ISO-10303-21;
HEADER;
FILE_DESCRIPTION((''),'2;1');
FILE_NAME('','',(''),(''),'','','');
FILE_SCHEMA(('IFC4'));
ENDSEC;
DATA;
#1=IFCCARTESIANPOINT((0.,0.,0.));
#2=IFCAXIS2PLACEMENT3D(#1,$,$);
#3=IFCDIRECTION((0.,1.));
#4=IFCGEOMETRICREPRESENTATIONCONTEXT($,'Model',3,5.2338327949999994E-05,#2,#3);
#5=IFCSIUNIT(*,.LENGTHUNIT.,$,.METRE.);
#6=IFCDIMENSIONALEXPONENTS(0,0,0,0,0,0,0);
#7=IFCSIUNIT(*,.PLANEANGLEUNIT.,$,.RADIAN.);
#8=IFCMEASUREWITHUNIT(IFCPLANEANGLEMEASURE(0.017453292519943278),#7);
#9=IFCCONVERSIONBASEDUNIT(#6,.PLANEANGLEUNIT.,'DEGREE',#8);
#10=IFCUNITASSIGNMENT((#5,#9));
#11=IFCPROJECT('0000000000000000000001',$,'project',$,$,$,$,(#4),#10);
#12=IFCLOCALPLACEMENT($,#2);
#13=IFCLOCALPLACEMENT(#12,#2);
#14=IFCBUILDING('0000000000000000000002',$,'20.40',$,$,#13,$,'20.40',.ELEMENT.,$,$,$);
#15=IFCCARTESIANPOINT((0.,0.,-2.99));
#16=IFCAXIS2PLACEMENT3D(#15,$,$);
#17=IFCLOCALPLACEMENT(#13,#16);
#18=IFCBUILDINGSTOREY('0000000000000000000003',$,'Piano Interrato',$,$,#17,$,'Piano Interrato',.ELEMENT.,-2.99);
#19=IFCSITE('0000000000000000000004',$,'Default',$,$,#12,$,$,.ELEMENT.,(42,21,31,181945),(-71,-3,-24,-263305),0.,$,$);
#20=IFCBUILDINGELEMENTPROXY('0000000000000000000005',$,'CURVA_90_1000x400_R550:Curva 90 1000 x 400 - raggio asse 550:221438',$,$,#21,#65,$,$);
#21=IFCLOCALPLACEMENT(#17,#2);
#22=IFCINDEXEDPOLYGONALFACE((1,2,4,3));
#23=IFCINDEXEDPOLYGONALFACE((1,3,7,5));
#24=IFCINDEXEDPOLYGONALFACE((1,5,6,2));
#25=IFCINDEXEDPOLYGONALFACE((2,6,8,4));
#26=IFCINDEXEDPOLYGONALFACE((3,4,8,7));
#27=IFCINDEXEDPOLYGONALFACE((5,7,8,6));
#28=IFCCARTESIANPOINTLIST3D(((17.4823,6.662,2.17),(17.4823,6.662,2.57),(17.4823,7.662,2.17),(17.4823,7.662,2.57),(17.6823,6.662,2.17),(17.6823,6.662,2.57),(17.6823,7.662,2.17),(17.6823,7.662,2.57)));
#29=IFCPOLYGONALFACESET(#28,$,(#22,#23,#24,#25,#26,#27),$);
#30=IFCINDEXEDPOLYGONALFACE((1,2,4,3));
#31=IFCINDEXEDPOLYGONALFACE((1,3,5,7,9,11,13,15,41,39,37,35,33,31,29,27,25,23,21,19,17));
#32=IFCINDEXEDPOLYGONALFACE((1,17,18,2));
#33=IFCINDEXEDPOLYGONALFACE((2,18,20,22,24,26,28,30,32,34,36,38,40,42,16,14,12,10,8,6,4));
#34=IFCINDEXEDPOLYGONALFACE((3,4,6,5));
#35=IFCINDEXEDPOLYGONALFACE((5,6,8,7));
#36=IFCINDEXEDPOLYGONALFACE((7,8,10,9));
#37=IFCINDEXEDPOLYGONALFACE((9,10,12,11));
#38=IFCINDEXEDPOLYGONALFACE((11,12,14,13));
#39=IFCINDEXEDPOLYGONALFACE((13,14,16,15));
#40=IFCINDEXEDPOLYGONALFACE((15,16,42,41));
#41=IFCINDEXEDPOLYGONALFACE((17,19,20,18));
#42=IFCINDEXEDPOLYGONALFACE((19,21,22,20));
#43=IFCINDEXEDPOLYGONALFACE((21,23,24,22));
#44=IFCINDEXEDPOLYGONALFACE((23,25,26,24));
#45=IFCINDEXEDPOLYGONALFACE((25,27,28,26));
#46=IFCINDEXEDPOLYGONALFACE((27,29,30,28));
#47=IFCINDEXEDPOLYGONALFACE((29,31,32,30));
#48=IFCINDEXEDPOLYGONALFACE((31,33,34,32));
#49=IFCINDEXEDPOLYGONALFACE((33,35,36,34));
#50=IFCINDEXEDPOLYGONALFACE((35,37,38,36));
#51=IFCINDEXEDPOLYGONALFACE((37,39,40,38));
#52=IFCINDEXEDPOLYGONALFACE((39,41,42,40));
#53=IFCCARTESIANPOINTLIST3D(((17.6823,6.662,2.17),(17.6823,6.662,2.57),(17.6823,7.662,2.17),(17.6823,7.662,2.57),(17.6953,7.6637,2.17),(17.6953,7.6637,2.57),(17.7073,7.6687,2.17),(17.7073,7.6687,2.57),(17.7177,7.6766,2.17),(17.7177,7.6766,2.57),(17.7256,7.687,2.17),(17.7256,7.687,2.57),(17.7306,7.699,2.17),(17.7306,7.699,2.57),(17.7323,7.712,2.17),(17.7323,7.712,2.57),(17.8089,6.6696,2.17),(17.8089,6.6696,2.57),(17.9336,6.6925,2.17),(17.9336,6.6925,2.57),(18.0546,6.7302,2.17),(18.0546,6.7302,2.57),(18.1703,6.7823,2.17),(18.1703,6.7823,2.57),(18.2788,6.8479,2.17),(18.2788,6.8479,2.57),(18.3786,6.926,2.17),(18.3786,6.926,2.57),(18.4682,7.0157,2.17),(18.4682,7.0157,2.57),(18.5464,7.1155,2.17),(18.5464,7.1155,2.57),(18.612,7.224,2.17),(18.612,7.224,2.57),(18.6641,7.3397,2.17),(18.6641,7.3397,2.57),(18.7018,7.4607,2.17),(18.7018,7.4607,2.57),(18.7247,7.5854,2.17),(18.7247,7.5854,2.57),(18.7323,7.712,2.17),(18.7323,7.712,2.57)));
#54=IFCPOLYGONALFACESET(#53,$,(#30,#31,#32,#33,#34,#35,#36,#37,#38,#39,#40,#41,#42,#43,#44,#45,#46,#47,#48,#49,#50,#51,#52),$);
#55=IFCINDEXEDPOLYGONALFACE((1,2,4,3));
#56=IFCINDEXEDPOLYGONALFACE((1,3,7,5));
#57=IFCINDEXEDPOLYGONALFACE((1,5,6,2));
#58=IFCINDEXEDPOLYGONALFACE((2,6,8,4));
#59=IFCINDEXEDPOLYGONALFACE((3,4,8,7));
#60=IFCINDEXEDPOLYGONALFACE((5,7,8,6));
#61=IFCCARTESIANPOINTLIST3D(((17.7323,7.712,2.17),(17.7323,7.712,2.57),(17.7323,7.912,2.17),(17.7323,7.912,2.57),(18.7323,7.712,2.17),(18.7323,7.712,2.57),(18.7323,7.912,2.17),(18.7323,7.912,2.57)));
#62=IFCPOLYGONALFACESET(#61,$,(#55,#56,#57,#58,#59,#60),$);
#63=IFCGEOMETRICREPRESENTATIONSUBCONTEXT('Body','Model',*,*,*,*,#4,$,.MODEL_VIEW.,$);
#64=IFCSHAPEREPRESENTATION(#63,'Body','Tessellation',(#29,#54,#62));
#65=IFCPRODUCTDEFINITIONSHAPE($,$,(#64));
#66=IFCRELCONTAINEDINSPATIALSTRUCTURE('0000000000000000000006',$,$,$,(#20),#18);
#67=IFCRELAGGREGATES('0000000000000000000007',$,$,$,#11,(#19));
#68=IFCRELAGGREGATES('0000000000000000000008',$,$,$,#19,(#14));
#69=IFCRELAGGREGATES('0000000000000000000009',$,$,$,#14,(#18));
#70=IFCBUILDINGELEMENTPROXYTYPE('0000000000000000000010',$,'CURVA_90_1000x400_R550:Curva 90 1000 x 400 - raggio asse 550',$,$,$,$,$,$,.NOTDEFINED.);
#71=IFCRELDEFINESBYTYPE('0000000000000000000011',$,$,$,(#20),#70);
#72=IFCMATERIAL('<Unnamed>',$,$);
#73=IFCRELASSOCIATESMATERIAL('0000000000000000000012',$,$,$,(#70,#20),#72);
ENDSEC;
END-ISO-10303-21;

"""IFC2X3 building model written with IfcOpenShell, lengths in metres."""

from ifc_helpers import new_model, entity, si_unit, converted_unit, direction, frame, frame_2d, origin, origin_2d_with_axis, place, context, subcontext, project, spatial, polyline, circle_curve, parameter, trimmed, segment, composite_curve, rectangle, outline, extrude, source, transform, mapped, material, type_object, type_shapes, element, save


model = new_model("IFC2X3")

# Units and contexts
model_context = context("Model", 3, precision=5.2338327949999994e-05, world=origin(), true_north=direction((0.0, 1.0)))
body_context = subcontext(model_context, "Body", "Model", "MODEL_VIEW")
ifc_project = project(units=[si_unit("LENGTHUNIT", "METRE"), converted_unit("PLANEANGLEUNIT", "DEGREE", entity("IfcPlaneAngleMeasure", 0.017453292519943278), si_unit("PLANEANGLEUNIT", "RADIAN"), dimensions=[0, 0, 0, 0, 0, 0, 0])], contexts=[model_context])

# Site, building, storey
site_placement = place(None, origin())
site = spatial("IfcSite", under=ifc_project, at=site_placement, Name="Default", CompositionType="ELEMENT", RefLatitude=(42, 21, 31, 181945), RefLongitude=(-71, -3, -24, -263305), RefElevation=0.0)
building_placement = place(site_placement, origin())
building = spatial("IfcBuilding", under=site, at=building_placement, Name="20.40", LongName="20.40", CompositionType="ELEMENT")
storey_placement = place(building_placement, frame((0.0, 0.0, -2.99)))
storey = spatial("IfcBuildingStorey", under=building, at=storey_placement, Name="Piano Interrato", LongName="Piano Interrato", CompositionType="ELEMENT", Elevation=-2.99)

# Shared definitions
ifc_material_1 = material(Name="<Unnamed>")

# Building element proxy
building_element_proxy_type_1 = type_object("IfcBuildingElementProxyType", Name="CURVA_90_1000x400_R550:Curva 90 1000 x 400 - raggio asse 550", PredefinedType="NOTDEFINED", material=ifc_material_1)
shared_shape_1 = source(origin(), body_context, "Body", "SweptSolid", [
    extrude(rectangle(XDim=0.2, YDim=1.0, at=origin_2d_with_axis()), frame((0.55, -0.1, -0.2), z_axis=(0.0, 0.0, 1.0), x_axis=(0.0, -1.0, 0.0)), (0.0, 0.0, 1.0), 0.4),
    extrude(outline(composite_curve([segment(polyline([(-0.775, -0.275), (0.225, -0.275)]), True, "CONTINUOUS"), segment(trimmed(circle_curve(frame_2d((0.275, -0.275), x_axis=(0.0, 1.0)), 0.05), [parameter(0.0)], [parameter(90.0)], True, "PARAMETER"), False, "CONTINUOUS"), segment(polyline([(0.275, -0.225), (0.275, 0.775)]), True, "CONTINUOUS"), segment(trimmed(circle_curve(frame_2d((0.275, -0.275), x_axis=(0.0, 1.0)), 1.05), [parameter(0.0)], [parameter(90.0)], True, "PARAMETER"), True, "CONTINUOUS")], self_intersect=False)), frame((0.275, 0.275, -0.2), z_axis=(0.0, 0.0, 1.0), x_axis=(0.0, -1.0, 0.0)), (0.0, 0.0, 1.0), 0.4),
    extrude(rectangle(XDim=0.2, YDim=1.0, at=origin_2d_with_axis()), frame((-0.1, 0.55, -0.2), z_axis=(0.0, 0.0, 1.0), x_axis=(-1.0, 0.0, 0.0)), (0.0, 0.0, 1.0), 0.4),
])
type_shapes(building_element_proxy_type_1, [shared_shape_1])
proxy_1_placement = place(storey_placement, frame((17.6823, 7.712, 2.37), z_axis=(0.0, 0.0, 1.0), x_axis=(0.0, -1.0, 0.0)))
element("IfcBuildingElementProxy", 1, at=proxy_1_placement, inside=storey, type_object=building_element_proxy_type_1, material=ifc_material_1, Name="CURVA_90_1000x400_R550:Curva 90 1000 x 400 - raggio asse 550:221438", context=body_context, shape_type="MappedRepresentation", body=[
    mapped(shared_shape_1, transform((0.0, 0.0, 0.0), scale=1.0)),
])

save(model, "model.ifc")
